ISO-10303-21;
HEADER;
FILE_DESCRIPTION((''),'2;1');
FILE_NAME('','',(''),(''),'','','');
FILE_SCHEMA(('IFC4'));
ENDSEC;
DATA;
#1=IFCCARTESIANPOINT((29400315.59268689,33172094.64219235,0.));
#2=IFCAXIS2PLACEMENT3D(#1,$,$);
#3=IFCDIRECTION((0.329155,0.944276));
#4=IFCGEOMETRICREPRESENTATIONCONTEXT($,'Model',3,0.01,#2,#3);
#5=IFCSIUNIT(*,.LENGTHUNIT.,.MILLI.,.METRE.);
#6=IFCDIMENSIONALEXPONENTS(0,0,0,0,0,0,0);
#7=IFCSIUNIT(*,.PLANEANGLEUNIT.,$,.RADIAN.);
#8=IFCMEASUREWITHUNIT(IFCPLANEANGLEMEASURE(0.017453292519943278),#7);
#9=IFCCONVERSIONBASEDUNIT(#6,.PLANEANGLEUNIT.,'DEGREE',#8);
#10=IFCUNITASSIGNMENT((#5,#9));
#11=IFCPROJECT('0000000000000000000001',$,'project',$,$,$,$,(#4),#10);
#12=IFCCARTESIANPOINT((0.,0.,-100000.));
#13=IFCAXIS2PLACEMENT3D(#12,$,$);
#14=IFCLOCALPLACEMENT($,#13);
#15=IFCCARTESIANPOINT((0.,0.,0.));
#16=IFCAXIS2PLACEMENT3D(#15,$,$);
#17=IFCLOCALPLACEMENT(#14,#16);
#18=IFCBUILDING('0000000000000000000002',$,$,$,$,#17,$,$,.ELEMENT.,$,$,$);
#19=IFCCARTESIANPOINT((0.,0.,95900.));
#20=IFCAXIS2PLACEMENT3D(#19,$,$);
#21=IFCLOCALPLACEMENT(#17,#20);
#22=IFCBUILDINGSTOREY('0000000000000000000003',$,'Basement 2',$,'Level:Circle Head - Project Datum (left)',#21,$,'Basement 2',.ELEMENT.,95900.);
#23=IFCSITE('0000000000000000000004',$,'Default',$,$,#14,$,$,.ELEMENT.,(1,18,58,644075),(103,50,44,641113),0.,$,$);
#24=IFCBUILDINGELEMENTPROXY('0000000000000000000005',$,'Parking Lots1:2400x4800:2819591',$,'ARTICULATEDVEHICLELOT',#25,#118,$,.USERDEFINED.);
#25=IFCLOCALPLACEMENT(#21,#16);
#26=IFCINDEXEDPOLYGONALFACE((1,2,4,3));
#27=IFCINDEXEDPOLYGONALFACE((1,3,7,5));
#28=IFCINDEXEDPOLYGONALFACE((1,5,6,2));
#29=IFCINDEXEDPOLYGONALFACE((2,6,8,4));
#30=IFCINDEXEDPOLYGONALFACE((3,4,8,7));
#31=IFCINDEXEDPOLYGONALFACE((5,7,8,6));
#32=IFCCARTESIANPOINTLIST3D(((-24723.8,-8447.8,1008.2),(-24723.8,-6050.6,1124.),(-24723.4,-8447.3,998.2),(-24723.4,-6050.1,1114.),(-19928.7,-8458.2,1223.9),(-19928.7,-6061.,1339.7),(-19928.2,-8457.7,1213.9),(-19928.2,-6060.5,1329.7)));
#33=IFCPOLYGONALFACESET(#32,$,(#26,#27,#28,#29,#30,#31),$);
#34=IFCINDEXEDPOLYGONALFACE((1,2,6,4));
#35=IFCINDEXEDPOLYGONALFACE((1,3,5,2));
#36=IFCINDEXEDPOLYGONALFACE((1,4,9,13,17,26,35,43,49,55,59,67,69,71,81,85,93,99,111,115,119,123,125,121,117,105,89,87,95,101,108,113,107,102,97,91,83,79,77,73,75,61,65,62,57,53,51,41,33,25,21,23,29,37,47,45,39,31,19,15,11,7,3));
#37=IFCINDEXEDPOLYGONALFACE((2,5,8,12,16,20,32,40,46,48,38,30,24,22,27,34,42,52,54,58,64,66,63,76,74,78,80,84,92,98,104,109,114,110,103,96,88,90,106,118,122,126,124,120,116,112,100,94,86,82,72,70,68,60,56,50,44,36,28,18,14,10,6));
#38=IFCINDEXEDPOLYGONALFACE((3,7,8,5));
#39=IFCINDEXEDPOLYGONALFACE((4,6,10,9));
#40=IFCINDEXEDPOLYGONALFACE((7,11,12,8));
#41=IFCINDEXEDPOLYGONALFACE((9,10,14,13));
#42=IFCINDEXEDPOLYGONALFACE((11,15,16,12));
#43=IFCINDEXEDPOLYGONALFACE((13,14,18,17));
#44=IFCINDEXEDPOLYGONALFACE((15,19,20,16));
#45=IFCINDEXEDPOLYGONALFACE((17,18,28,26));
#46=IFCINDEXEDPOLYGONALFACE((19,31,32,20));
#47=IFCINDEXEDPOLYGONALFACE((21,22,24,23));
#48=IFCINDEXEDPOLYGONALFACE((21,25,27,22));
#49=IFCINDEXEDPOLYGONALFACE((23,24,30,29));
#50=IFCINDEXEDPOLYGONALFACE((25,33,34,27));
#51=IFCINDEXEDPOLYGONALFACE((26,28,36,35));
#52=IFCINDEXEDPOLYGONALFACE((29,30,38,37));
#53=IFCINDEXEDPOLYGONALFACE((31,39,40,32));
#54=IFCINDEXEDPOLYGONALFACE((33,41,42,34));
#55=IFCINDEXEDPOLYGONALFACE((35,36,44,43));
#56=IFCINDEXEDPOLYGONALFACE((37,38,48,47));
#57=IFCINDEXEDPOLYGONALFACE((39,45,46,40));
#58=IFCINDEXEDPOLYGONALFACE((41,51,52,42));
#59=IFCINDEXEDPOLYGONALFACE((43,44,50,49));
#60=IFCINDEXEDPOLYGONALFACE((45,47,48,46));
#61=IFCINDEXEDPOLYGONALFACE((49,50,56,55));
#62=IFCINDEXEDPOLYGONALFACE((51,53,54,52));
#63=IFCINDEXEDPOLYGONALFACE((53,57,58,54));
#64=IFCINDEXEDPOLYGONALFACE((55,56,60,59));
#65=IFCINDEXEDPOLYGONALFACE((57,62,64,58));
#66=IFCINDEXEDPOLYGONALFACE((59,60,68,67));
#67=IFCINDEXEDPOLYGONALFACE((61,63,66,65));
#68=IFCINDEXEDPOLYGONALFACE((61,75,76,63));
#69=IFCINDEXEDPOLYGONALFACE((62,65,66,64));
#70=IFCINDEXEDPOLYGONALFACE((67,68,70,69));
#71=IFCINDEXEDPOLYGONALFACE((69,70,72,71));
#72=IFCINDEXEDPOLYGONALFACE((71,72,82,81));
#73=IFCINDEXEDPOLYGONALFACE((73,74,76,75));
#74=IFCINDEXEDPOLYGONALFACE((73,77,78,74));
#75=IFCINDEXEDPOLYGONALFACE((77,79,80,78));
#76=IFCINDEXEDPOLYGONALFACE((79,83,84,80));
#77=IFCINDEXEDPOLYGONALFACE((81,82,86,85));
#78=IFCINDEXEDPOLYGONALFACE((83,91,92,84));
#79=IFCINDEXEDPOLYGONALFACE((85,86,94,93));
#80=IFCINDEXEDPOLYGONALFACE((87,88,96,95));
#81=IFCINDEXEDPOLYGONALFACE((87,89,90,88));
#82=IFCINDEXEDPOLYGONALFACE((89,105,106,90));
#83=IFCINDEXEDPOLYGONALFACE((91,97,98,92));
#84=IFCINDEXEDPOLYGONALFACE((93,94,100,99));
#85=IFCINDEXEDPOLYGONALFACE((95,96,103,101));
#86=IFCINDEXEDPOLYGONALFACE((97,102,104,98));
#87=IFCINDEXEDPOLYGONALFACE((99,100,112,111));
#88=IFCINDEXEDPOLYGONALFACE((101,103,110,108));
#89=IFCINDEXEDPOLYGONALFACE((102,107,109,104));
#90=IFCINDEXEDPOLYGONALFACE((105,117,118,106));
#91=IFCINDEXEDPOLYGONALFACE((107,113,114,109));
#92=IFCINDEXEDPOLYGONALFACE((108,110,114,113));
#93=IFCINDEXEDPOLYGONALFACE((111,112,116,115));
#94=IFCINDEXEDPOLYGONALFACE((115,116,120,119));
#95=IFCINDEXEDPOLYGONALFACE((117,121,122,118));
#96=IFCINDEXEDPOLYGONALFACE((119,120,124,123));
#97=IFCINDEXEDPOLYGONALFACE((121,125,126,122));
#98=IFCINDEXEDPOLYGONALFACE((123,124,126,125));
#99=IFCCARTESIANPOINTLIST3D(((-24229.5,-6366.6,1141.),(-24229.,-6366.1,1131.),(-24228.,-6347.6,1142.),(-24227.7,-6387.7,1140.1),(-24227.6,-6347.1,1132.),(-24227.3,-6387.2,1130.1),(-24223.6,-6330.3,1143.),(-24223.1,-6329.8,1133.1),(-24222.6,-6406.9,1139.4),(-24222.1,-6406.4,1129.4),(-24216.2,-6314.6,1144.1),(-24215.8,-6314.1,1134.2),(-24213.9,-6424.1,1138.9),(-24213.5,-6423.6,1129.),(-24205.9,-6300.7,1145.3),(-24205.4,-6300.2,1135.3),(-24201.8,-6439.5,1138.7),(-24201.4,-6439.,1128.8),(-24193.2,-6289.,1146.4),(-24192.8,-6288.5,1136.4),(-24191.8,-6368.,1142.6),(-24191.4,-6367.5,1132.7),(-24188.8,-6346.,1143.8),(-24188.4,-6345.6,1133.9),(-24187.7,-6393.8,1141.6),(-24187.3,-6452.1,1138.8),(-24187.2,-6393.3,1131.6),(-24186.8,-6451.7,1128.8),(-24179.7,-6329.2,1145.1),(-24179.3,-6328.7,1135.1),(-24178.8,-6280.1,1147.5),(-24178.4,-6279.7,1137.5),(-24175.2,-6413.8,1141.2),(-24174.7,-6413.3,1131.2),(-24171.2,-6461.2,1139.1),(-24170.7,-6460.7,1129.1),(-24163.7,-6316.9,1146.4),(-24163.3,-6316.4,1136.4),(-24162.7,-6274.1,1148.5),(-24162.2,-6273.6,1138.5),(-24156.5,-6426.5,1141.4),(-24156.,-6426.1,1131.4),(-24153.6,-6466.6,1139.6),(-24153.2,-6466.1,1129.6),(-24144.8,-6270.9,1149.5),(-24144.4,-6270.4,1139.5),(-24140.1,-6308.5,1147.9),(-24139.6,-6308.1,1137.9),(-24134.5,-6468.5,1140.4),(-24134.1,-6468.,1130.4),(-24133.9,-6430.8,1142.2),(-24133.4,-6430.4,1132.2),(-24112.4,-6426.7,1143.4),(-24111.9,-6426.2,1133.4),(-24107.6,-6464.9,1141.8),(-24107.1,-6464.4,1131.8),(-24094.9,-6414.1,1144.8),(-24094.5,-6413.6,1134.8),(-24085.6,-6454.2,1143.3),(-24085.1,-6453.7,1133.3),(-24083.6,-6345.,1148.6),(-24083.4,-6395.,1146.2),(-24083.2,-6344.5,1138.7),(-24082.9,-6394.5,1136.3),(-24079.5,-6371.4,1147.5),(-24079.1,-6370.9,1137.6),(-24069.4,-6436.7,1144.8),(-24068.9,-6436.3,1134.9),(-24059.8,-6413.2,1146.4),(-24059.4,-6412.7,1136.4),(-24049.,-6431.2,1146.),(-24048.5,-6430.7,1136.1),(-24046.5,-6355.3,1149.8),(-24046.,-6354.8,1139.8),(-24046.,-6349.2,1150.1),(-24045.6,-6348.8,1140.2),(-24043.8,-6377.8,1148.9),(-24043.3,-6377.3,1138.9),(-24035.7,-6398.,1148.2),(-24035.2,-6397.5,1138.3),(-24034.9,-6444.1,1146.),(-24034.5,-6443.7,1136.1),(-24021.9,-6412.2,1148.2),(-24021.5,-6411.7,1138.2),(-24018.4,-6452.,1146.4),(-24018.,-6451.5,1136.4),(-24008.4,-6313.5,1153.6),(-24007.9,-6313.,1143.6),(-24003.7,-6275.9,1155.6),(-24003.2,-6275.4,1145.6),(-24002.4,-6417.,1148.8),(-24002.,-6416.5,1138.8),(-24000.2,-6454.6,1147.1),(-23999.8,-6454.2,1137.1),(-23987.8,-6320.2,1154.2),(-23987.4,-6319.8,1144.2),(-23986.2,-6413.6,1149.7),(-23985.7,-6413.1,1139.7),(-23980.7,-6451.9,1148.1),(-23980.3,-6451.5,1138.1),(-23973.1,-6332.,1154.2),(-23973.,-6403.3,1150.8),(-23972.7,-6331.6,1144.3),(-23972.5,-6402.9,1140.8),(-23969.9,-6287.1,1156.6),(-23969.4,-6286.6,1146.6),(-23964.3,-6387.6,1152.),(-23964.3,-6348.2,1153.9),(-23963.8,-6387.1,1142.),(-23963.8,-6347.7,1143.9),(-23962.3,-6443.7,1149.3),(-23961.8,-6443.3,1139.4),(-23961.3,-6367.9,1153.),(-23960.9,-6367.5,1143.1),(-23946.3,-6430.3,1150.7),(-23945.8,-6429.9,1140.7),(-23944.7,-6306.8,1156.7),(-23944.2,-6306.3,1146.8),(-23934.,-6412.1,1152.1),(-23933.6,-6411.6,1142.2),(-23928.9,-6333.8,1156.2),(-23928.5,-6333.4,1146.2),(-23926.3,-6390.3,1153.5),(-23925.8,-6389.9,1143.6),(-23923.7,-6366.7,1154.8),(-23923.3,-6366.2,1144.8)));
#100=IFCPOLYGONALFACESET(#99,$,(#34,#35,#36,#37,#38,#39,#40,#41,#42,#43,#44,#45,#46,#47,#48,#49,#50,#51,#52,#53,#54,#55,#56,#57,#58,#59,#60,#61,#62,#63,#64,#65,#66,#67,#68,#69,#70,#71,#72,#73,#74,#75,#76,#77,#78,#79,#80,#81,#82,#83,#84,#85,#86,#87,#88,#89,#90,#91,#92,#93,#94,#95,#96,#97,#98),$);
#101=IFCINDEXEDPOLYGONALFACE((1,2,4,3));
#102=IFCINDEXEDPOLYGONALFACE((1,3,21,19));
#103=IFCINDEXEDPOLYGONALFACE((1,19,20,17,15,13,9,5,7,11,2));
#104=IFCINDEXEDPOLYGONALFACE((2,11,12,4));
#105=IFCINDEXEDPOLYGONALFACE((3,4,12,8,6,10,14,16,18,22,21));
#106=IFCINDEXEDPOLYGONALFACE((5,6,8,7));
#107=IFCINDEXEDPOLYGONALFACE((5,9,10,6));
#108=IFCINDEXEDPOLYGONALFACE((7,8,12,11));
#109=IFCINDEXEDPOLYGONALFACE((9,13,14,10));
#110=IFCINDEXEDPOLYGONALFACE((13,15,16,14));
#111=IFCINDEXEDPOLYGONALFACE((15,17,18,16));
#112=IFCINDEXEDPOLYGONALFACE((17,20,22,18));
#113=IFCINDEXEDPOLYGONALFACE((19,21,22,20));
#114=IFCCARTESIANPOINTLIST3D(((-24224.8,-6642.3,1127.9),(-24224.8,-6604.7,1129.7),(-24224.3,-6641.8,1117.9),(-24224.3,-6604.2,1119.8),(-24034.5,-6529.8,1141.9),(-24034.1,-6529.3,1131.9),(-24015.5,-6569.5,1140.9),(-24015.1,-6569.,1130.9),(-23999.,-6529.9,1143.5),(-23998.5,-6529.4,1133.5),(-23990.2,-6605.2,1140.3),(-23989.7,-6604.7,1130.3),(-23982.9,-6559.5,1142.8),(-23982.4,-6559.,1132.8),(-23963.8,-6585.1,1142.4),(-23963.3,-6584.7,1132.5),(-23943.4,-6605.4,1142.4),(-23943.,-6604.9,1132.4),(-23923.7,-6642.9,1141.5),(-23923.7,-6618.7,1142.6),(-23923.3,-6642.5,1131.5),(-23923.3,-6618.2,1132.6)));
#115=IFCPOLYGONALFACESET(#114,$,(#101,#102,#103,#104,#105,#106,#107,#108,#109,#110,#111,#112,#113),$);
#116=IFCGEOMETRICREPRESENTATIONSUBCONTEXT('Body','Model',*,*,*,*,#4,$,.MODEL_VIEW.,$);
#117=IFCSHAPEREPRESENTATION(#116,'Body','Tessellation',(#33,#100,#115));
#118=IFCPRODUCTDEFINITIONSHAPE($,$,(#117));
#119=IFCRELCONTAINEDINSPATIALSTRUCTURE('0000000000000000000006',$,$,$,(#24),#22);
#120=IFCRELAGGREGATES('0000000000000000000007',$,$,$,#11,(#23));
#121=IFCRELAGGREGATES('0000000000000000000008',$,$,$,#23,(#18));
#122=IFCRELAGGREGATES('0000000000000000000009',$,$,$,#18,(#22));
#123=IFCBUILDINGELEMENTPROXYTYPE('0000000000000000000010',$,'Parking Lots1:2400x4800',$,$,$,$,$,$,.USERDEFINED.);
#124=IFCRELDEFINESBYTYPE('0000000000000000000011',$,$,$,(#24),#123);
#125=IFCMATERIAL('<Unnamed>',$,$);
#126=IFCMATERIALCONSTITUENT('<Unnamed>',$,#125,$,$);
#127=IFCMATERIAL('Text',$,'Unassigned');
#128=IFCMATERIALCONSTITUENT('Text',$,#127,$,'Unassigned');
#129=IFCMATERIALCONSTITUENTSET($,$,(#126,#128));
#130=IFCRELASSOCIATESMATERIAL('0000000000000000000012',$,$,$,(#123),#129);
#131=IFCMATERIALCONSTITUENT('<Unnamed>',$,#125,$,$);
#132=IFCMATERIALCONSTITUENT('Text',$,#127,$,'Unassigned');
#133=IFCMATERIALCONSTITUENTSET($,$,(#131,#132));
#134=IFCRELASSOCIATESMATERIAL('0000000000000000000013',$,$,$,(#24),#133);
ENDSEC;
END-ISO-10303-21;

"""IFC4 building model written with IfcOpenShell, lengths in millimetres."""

from ifc_helpers import new_model, entity, si_unit, converted_unit, direction, frame, origin, place, context, subcontext, project, spatial, indexed_curve, outline, extrude, source, transform, mapped, material, constituent, constituent_set, type_object, type_shapes, element, save


model = new_model("IFC4")

# Units and contexts
model_context = context("Model", 3, precision=0.01, world=frame((29400315.59268689, 33172094.64219235, 0.0)), true_north=direction((0.329155, 0.944276)))
body_context = subcontext(model_context, "Body", "Model", "MODEL_VIEW")
ifc_project = project(units=[si_unit("LENGTHUNIT", "METRE", prefix="MILLI"), converted_unit("PLANEANGLEUNIT", "DEGREE", entity("IfcPlaneAngleMeasure", 0.017453292519943278), si_unit("PLANEANGLEUNIT", "RADIAN"), dimensions=[0, 0, 0, 0, 0, 0, 0])], contexts=[model_context])

# Site, building, storey
site_placement = place(None, frame((0.0, 0.0, -100000.0)))
site = spatial("IfcSite", under=ifc_project, at=site_placement, Name="Default", CompositionType="ELEMENT", RefLatitude=(1, 18, 58, 644075), RefLongitude=(103, 50, 44, 641113), RefElevation=0.0)
building_placement = place(site_placement, origin())
building = spatial("IfcBuilding", under=site, at=building_placement, CompositionType="ELEMENT")
storey_placement = place(building_placement, frame((0.0, 0.0, 95900.0)))
storey = spatial("IfcBuildingStorey", under=building, at=storey_placement, Name="Basement 2", ObjectType="Level:Circle Head - Project Datum (left)", LongName="Basement 2", CompositionType="ELEMENT", Elevation=95900.0)

# Shared definitions
ifc_material_1 = material(Name="<Unnamed>")

# Building element proxy
ifc_material_2 = material(Name="Text", Category="Unassigned")
ifc_constituent_1 = constituent(ifc_material_1, Name="<Unnamed>")
ifc_constituent_2 = constituent(ifc_material_2, Name="Text", Category="Unassigned")
ifc_constituent_set_1 = constituent_set(constituents=[ifc_constituent_1, ifc_constituent_2])
ifc_constituent_3 = constituent(ifc_material_1, Name="<Unnamed>")
ifc_constituent_4 = constituent(ifc_material_2, Name="Text", Category="Unassigned")
ifc_constituent_set_2 = constituent_set(constituents=[ifc_constituent_3, ifc_constituent_4])
building_element_proxy_type_1 = type_object("IfcBuildingElementProxyType", Name="Parking Lots1:2400x4800", PredefinedType="USERDEFINED", material=ifc_constituent_set_2)
shared_shape_1 = source(origin(), body_context, "Body", "SweptSolid", [
    extrude(outline(indexed_curve([(-1200.0, -2400.0), (1200.0, -2400.0), (1200.0, 2400.0), (-1200.0, 2400.0), (-1200.0, -2400.0)], self_intersect=False)), frame((1200.0, -2400.0, 0.0), z_axis=(0.0, 0.0, 1.0), x_axis=(-1.0, 0.0, 0.0)), (0.0, 0.0, 1.0), 10.0),
    extrude(outline(indexed_curve([(41.2, -119.5), (59.4, -119.5), (76.4, -116.4), (92.1, -110.3), (106.7, -101.0), (119.4, -89.1), (129.4, -75.0), (136.9, -58.7), (141.8, -40.2), (143.8, -19.2), (142.2, 0.6), (136.7, 19.2), (127.6, 36.5), (115.5, 51.5), (101.3, 63.2), (84.9, 71.7), (66.4, 76.9), (39.2, 78.2), (15.6, 71.5), (-3.5, 57.2), (-17.0, 35.7), (-24.5, 55.3), (-36.1, 70.5), (-50.9, 81.2), (-68.4, 87.0), (-88.1, 87.8), (-107.7, 83.0), (-125.9, 72.6), (-141.2, 56.8), (-152.7, 36.8), (-159.5, 13.9), (-160.2, -19.4), (-149.6, -48.7), (-128.2, -72.7), (-96.9, -89.6), (-85.6, -53.4), (-104.7, -43.2), (-117.0, -28.9), (-122.8, -11.5), (-122.2, 8.5), (-115.8, 27.4), (-104.4, 41.3), (-89.5, 49.1), (-72.9, 49.6), (-54.6, 41.4), (-43.6, 24.9), (-39.2, 3.6), (-40.6, -19.0), (-42.1, -24.9), (-5.8, -35.8), (-5.1, -9.0), (2.9, 13.6), (17.7, 30.3), (37.1, 39.7), (59.0, 40.0), (80.6, 31.7), (96.7, 15.8), (105.4, -6.0), (104.9, -32.2), (98.0, -53.3), (86.0, -68.3), (68.1, -77.6), (43.3, -81.6), (41.2, -119.5)], self_intersect=False)), frame((329.1, -4158.0, 10.0), z_axis=(0.0, 0.0, 1.0), x_axis=(0.178774, -0.98389, 0.0)), (0.0, 0.0, 1.0), 10.0),
    extrude(outline(indexed_curve([(-204.4, -52.5), (97.0, -52.5), (97.0, -28.2), (77.2, -14.9), (56.9, 5.3), (37.7, 30.9), (21.6, 60.5), (-14.0, 60.5), (5.0, 20.8), (30.4, -14.9), (-204.4, -14.9), (-204.4, -52.5)], self_intersect=False)), frame((538.3, -4095.6, 10.0), z_axis=(0.0, 0.0, 1.0), x_axis=(0.0, 1.0, 0.0)), (0.0, 0.0, 1.0), 10.0),
])
type_shapes(building_element_proxy_type_1, [shared_shape_1])
proxy_1_placement = place(storey_placement, frame((-19928.2, -6060.5, 1329.7), z_axis=(-0.044986, -0.048198, 0.997824), x_axis=(0.0, -0.998835, -0.048247)))
element("IfcBuildingElementProxy", 1, at=proxy_1_placement, inside=storey, type_object=building_element_proxy_type_1, material=ifc_constituent_set_1, Name="Parking Lots1:2400x4800:2819591", ObjectType="ARTICULATEDVEHICLELOT", PredefinedType="USERDEFINED", context=body_context, shape_type="MappedRepresentation", body=[
    mapped(shared_shape_1, transform((0.0, 0.0, 0.0), scale=1.0)),
])

save(model, "model.ifc")
